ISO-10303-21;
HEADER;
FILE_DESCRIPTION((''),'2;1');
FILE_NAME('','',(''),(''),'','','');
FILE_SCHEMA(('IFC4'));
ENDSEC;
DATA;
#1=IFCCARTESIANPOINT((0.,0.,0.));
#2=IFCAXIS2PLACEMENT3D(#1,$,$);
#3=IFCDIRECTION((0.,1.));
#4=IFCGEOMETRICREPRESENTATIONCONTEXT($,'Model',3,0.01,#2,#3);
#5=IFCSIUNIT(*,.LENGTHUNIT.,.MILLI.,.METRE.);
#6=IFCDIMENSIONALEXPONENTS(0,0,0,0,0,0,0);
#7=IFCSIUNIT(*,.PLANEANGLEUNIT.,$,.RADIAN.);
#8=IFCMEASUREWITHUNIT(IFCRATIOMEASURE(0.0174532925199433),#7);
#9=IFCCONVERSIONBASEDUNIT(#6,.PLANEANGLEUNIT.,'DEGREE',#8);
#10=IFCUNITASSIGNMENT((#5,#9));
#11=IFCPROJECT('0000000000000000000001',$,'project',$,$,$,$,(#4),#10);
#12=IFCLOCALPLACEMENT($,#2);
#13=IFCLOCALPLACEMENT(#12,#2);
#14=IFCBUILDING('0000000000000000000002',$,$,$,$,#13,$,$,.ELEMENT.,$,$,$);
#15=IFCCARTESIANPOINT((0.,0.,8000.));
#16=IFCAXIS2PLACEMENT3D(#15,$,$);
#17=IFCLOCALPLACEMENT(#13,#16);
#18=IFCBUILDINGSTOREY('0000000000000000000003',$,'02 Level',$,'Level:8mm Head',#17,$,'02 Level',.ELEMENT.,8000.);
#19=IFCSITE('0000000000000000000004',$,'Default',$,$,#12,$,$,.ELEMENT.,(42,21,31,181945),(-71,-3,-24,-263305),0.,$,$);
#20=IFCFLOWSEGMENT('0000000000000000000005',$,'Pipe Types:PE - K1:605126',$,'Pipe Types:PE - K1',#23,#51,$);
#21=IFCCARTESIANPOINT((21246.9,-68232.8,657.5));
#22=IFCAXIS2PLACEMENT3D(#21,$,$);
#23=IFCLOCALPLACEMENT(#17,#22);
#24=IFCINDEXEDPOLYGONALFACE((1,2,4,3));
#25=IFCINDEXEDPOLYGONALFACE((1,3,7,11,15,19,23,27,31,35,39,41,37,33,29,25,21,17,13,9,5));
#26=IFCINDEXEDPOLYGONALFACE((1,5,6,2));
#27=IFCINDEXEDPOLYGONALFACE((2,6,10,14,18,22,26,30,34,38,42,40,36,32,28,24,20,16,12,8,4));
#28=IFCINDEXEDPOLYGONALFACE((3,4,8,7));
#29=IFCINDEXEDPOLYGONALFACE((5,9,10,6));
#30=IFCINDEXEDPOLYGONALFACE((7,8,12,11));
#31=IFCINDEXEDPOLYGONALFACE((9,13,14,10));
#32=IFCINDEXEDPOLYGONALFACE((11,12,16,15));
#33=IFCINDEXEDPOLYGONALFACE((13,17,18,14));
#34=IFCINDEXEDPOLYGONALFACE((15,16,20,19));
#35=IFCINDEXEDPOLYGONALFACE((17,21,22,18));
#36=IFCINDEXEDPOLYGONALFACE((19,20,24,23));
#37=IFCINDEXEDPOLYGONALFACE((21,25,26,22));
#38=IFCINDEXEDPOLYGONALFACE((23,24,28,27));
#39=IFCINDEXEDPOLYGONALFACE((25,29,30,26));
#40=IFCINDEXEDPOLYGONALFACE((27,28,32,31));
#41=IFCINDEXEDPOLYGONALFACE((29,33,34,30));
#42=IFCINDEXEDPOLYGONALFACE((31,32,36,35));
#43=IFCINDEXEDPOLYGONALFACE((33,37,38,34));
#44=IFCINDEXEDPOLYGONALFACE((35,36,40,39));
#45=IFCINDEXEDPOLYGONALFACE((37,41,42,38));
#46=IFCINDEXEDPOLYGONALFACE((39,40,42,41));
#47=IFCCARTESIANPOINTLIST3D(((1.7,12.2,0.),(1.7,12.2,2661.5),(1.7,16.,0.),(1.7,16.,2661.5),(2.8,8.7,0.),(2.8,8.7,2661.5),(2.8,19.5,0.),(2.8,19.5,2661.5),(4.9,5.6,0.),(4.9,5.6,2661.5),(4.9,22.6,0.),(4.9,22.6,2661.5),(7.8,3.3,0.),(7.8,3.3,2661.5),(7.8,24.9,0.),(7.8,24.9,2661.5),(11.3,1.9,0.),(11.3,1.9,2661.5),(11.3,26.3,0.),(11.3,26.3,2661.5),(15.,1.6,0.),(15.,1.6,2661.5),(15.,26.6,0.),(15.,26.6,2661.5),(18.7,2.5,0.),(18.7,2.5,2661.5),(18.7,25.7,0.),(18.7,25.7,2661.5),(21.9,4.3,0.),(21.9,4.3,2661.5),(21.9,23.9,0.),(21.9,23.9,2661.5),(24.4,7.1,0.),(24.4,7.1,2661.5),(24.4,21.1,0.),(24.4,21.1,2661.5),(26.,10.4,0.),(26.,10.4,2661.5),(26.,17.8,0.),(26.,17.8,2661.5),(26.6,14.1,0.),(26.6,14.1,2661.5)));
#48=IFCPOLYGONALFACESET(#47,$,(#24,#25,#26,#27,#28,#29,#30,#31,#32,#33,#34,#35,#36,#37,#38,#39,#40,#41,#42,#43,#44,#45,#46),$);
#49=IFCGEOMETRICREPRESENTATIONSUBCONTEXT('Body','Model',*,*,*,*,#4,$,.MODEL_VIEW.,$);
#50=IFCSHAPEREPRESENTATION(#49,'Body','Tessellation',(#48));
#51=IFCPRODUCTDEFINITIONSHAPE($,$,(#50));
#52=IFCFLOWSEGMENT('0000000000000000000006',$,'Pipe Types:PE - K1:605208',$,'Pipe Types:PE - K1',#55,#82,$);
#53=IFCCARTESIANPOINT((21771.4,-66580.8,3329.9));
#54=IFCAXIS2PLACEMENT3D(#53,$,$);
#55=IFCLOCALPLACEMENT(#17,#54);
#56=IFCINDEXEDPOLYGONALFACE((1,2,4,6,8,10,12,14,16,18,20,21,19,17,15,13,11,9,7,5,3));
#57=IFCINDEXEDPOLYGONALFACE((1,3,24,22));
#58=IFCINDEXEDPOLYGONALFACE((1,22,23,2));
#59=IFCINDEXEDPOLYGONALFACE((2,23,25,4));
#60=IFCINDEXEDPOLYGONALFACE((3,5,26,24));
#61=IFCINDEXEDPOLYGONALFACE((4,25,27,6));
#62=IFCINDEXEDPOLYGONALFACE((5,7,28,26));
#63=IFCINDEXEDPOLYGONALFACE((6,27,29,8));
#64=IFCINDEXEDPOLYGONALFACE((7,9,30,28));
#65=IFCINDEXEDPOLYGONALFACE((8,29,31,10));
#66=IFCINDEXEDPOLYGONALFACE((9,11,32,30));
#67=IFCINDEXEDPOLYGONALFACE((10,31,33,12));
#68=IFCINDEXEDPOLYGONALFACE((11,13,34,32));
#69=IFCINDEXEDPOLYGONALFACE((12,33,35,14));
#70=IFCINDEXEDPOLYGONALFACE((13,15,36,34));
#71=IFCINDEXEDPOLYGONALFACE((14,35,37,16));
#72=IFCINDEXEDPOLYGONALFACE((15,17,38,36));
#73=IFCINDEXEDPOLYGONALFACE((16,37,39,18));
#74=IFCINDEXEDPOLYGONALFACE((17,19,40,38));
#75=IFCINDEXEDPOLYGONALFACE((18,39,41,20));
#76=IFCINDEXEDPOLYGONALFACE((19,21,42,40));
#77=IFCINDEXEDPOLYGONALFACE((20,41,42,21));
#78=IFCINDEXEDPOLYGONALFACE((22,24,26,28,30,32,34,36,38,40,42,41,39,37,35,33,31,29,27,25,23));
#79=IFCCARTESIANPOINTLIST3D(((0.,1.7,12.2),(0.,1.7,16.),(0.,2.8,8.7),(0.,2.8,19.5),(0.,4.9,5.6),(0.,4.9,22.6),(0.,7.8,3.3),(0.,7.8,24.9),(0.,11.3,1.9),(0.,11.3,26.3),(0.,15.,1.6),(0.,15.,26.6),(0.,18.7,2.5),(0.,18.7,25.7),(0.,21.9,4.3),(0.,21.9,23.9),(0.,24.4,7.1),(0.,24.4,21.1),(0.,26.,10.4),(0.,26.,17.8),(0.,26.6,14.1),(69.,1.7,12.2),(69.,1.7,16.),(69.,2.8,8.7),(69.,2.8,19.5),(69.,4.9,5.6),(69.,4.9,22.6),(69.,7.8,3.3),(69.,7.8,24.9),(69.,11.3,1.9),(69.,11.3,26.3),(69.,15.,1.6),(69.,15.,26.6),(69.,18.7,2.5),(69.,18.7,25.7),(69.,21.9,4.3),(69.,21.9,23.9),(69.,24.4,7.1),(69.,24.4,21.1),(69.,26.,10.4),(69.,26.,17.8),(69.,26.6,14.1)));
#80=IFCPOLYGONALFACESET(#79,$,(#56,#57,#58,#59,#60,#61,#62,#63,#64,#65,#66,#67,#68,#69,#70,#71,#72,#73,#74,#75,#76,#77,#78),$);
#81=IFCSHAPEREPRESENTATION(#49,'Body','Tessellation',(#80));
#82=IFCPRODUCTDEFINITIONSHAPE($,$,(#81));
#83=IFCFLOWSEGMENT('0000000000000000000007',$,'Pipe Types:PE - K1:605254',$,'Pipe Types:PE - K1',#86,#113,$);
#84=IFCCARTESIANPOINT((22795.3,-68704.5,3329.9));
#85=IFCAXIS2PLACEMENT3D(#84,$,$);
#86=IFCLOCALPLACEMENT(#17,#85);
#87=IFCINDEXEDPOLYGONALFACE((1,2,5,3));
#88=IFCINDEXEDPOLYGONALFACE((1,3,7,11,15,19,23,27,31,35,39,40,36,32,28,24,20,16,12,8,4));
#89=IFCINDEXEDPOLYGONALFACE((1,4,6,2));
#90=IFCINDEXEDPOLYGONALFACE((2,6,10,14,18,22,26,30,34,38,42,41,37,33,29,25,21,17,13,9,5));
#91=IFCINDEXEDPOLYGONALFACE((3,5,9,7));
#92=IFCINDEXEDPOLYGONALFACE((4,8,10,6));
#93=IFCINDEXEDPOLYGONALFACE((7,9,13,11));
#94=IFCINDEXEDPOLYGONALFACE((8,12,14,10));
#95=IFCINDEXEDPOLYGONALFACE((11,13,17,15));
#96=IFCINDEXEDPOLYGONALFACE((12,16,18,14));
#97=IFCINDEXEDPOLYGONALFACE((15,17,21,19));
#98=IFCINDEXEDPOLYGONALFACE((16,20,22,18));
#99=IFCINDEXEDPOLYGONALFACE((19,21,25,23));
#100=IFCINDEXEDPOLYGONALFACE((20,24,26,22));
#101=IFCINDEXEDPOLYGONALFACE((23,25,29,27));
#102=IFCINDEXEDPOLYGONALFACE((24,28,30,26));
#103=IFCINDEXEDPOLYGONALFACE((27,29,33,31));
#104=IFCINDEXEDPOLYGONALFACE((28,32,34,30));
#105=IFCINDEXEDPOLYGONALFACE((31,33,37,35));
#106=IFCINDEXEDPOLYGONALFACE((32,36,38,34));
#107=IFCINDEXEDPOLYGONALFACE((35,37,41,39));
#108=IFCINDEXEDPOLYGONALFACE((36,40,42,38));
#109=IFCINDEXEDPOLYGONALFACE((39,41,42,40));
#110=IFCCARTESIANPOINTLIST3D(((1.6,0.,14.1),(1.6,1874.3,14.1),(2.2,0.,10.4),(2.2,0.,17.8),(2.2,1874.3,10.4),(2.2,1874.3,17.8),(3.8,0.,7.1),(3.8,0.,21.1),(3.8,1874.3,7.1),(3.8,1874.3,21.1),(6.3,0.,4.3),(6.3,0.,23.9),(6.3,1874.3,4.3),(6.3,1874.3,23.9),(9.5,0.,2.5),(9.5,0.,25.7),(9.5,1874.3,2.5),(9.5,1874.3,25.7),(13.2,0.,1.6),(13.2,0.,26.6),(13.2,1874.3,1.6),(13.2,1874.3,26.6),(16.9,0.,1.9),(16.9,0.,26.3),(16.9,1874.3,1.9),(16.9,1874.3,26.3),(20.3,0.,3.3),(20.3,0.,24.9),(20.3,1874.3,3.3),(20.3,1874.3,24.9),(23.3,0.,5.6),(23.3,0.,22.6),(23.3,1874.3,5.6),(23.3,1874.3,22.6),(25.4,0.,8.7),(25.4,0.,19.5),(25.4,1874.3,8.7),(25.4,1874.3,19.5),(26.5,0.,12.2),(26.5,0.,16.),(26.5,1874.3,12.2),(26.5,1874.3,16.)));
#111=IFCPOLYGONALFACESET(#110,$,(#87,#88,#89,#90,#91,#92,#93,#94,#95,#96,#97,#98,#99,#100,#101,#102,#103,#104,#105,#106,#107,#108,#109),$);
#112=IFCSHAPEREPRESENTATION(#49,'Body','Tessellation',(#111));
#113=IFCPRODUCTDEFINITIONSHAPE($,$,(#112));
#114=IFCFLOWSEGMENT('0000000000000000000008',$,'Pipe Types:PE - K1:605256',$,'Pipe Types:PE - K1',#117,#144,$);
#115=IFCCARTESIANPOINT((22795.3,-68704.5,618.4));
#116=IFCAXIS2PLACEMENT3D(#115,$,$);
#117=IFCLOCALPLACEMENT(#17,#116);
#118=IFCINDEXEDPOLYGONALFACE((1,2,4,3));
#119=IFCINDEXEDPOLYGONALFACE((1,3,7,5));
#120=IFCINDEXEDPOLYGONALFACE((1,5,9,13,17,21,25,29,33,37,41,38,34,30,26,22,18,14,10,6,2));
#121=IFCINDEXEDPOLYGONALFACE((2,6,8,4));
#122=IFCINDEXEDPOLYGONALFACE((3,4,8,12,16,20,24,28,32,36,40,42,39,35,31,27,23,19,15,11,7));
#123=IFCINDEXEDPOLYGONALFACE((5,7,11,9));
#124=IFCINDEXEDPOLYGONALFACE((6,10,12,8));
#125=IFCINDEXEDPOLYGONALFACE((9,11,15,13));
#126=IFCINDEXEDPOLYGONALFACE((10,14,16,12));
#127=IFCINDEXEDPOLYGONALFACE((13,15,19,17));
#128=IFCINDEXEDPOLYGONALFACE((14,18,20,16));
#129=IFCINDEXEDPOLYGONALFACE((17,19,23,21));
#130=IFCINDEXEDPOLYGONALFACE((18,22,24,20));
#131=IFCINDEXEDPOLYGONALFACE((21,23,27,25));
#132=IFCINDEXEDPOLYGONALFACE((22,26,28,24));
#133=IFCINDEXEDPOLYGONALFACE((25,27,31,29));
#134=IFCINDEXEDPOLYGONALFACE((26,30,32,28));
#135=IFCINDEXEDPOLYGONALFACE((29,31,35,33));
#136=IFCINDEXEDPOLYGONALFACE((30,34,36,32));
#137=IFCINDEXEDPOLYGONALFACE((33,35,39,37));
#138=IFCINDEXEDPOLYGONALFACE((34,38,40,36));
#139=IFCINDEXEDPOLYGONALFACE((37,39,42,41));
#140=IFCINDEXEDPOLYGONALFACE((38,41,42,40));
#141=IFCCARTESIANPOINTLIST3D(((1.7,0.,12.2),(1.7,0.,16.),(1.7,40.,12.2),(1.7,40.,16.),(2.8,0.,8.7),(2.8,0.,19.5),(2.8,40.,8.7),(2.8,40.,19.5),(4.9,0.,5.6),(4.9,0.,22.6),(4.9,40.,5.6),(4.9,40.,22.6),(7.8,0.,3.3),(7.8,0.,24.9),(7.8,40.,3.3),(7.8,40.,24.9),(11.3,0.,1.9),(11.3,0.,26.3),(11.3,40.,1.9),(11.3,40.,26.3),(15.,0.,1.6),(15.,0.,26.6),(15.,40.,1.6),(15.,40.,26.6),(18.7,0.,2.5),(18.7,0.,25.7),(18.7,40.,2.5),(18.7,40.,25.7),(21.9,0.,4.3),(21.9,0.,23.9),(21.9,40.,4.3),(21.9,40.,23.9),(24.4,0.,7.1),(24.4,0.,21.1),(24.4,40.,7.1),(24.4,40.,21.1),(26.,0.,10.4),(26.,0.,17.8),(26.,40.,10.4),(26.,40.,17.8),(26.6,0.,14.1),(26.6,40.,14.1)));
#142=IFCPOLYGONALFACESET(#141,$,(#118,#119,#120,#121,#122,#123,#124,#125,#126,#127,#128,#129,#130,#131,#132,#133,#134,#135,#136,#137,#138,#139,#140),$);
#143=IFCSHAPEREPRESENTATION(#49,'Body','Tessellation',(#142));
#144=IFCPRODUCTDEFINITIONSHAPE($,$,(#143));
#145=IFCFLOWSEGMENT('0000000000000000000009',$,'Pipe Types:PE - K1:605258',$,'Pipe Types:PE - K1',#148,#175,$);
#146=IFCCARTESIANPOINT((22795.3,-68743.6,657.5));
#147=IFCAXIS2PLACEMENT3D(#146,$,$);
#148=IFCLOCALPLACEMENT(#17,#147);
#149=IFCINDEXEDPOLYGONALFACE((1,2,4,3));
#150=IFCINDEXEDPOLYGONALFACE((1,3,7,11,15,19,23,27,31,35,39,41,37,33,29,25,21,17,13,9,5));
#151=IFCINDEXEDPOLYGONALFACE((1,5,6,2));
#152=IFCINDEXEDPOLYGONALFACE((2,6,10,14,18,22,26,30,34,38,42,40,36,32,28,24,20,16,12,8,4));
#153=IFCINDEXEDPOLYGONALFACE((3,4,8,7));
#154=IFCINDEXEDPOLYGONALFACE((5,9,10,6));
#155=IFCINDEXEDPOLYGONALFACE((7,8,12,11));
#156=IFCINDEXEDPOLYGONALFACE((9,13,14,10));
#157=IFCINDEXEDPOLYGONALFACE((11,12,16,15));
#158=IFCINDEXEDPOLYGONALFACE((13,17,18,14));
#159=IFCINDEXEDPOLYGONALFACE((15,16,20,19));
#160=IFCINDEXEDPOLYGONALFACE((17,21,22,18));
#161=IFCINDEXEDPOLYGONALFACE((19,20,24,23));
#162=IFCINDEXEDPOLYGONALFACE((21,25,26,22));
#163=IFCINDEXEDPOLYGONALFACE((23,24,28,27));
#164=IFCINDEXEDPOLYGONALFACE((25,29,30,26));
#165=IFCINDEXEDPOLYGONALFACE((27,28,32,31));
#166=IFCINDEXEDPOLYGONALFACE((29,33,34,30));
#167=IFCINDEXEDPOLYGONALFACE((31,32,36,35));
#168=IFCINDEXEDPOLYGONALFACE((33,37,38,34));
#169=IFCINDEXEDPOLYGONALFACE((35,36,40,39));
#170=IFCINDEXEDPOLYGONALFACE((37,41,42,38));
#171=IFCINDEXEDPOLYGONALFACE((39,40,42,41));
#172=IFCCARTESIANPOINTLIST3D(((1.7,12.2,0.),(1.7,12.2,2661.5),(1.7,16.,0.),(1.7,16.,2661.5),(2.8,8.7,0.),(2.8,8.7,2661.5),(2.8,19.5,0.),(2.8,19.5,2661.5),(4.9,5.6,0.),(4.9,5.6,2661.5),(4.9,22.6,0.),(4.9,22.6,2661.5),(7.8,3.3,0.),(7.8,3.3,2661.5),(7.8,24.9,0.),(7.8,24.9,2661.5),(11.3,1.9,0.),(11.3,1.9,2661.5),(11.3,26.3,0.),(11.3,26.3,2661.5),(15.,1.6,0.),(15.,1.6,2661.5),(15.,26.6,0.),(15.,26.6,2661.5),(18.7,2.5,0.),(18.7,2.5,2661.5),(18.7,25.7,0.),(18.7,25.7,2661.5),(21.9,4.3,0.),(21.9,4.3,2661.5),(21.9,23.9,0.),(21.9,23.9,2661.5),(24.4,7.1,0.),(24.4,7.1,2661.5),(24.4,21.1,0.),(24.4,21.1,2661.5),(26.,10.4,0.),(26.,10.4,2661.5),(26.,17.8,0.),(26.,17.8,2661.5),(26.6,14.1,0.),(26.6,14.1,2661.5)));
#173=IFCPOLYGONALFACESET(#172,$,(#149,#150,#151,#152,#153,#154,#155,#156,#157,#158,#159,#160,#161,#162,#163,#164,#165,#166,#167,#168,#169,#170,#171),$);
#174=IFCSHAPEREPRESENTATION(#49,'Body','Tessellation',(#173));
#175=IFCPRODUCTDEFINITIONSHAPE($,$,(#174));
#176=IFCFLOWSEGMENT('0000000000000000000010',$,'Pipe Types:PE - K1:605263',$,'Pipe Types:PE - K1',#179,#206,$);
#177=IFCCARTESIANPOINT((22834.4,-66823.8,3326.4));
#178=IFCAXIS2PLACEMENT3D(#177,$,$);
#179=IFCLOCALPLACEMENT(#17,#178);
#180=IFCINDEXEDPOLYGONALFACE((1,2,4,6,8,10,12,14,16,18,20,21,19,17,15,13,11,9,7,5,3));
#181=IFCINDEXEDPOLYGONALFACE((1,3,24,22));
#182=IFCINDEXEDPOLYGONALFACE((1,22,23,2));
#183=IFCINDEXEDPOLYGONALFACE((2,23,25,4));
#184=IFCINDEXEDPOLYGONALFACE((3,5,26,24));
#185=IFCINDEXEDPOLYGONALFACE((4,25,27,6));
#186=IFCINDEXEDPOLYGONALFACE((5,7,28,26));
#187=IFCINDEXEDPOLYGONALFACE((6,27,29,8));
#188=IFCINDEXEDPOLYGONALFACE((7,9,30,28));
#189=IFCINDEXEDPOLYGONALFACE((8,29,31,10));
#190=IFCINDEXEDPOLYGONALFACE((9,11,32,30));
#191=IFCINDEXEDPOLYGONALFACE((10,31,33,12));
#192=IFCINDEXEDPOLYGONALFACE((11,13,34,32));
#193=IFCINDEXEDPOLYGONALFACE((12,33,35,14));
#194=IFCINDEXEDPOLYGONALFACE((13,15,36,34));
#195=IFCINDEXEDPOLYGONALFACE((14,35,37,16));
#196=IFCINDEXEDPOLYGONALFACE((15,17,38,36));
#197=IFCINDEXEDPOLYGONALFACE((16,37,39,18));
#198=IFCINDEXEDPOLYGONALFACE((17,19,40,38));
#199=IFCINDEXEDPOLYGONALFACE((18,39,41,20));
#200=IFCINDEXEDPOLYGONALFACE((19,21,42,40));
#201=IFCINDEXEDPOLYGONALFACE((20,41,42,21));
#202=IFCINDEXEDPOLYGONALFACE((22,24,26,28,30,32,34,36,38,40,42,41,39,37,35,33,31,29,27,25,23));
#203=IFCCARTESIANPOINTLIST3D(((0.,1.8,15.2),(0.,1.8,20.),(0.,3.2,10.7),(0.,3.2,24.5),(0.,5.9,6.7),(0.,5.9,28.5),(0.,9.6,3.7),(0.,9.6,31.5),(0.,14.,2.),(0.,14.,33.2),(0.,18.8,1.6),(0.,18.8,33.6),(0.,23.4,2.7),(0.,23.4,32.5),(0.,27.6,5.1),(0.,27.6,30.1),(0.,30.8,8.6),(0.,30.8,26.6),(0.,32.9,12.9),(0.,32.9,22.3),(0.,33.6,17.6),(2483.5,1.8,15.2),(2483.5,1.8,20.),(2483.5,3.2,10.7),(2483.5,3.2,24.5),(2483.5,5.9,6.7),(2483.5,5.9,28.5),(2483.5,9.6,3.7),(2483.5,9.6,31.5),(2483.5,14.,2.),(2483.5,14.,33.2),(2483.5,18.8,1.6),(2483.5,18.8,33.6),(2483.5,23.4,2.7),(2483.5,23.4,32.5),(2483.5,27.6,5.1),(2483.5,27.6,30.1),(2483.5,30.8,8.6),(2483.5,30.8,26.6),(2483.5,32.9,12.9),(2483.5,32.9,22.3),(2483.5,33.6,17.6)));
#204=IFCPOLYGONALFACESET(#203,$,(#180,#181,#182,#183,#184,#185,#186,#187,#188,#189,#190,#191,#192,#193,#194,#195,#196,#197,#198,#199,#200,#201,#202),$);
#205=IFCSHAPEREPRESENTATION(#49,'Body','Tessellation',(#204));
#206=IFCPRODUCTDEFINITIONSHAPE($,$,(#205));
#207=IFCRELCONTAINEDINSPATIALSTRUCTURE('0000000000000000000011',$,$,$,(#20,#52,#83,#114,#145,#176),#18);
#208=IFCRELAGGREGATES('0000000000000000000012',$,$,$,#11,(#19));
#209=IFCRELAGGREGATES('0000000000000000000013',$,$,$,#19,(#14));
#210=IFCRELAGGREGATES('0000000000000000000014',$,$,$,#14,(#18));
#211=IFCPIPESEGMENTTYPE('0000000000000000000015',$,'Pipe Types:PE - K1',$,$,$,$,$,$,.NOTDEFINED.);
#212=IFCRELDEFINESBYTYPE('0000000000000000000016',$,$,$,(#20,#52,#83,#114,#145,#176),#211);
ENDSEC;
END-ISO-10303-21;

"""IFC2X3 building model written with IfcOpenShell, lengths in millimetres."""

from ifc_helpers import new_model, entity, si_unit, converted_unit, direction, frame, frame_2d, origin, origin_2d_with_axis, place, context, subcontext, project, spatial, circle, extrude, type_object, element, save


model = new_model("IFC2X3")

# Units and contexts
model_context = context("Model", 3, precision=0.01, world=origin(), true_north=direction((0.0, 1.0)))
body_context = subcontext(model_context, "Body", "Model", "MODEL_VIEW")
ifc_project = project(units=[si_unit("LENGTHUNIT", "METRE", prefix="MILLI"), converted_unit("PLANEANGLEUNIT", "DEGREE", entity("IfcRatioMeasure", 0.0174532925199433), si_unit("PLANEANGLEUNIT", "RADIAN"), dimensions=[0, 0, 0, 0, 0, 0, 0])], contexts=[model_context])

# Site, building, storey
site_placement = place(None, origin())
site = spatial("IfcSite", under=ifc_project, at=site_placement, Name="Default", CompositionType="ELEMENT", RefLatitude=(42, 21, 31, 181945), RefLongitude=(-71, -3, -24, -263305), RefElevation=0.0)
building_placement = place(site_placement, origin())
building = spatial("IfcBuilding", under=site, at=building_placement, CompositionType="ELEMENT")
storey_placement = place(building_placement, frame((0.0, 0.0, 8000.0)))
storey = spatial("IfcBuildingStorey", under=building, at=storey_placement, Name="02 Level", ObjectType="Level:8mm Head", LongName="02 Level", CompositionType="ELEMENT", Elevation=8000.0)

# Flow segments
pipe_segment_type = type_object("IfcPipeSegmentType", Name="Pipe Types:PE - K1", PredefinedType="NOTDEFINED")
flow_segment_1_placement = place(storey_placement, frame((21246.9, -68232.8, 657.5)))
element("IfcFlowSegment", 1, at=flow_segment_1_placement, inside=storey, type_object=pipe_segment_type, Name="Pipe Types:PE - K1:605126", ObjectType="Pipe Types:PE - K1", context=body_context, shape_type="SweptSolid", body=[
    extrude(circle(Radius=12.5, at=origin_2d_with_axis()), frame((14.1, 14.1, 0.0)), (0.0, 0.0, 1.0), 2661.5),
])
flow_segment_2_placement = place(storey_placement, frame((21771.4, -66580.8, 3329.9)))
element("IfcFlowSegment", 2, at=flow_segment_2_placement, inside=storey, type_object=pipe_segment_type, Name="Pipe Types:PE - K1:605208", ObjectType="Pipe Types:PE - K1", context=body_context, shape_type="SweptSolid", body=[
    extrude(circle(Radius=12.5, at=frame_2d((0.0, 0.0), x_axis=(1.0, 0.0))), frame((0.0, 14.1, 14.1), z_axis=(1.0, 0.0, 0.0), x_axis=(0.0, 1.0, 0.0)), (0.0, 0.0, 1.0), 69.0),
])
flow_segment_3_placement = place(storey_placement, frame((22795.3, -68704.5, 3329.9)))
element("IfcFlowSegment", 3, at=flow_segment_3_placement, inside=storey, type_object=pipe_segment_type, Name="Pipe Types:PE - K1:605254", ObjectType="Pipe Types:PE - K1", context=body_context, shape_type="SweptSolid", body=[
    extrude(circle(Radius=12.5, at=origin_2d_with_axis()), frame((14.1, 0.0, 14.1), z_axis=(0.0, 1.0, 0.0), x_axis=(-1.0, 0.0, 0.0)), (0.0, 0.0, 1.0), 1874.3),
])
flow_segment_4_placement = place(storey_placement, frame((22795.3, -68704.5, 618.4)))
element("IfcFlowSegment", 4, at=flow_segment_4_placement, inside=storey, type_object=pipe_segment_type, Name="Pipe Types:PE - K1:605256", ObjectType="Pipe Types:PE - K1", context=body_context, shape_type="SweptSolid", body=[
    extrude(circle(Radius=12.5, at=frame_2d((0.0, 0.0), x_axis=(1.0, 0.0))), frame((14.1, 0.0, 14.1), z_axis=(0.0, 1.0, 0.0), x_axis=(1.0, 0.0, 0.0)), (0.0, 0.0, 1.0), 40.0),
])
flow_segment_5_placement = place(storey_placement, frame((22795.3, -68743.6, 657.5)))
element("IfcFlowSegment", 5, at=flow_segment_5_placement, inside=storey, type_object=pipe_segment_type, Name="Pipe Types:PE - K1:605258", ObjectType="Pipe Types:PE - K1", context=body_context, shape_type="SweptSolid", body=[
    extrude(circle(Radius=12.5, at=frame_2d((0.0, 0.0), x_axis=(1.0, 0.0))), frame((14.1, 14.1, 0.0)), (0.0, 0.0, 1.0), 2661.5),
])
flow_segment_6_placement = place(storey_placement, frame((22834.4, -66823.8, 3326.4)))
element("IfcFlowSegment", 6, at=flow_segment_6_placement, inside=storey, type_object=pipe_segment_type, Name="Pipe Types:PE - K1:605263", ObjectType="Pipe Types:PE - K1", context=body_context, shape_type="SweptSolid", body=[
    extrude(circle(Radius=16.0, at=frame_2d((0.0, 0.0), x_axis=(1.0, 0.0))), frame((0.0, 17.6, 17.6), z_axis=(1.0, 0.0, 0.0), x_axis=(0.0, 1.0, 0.0)), (0.0, 0.0, 1.0), 2483.5),
])

save(model, "model.ifc")
